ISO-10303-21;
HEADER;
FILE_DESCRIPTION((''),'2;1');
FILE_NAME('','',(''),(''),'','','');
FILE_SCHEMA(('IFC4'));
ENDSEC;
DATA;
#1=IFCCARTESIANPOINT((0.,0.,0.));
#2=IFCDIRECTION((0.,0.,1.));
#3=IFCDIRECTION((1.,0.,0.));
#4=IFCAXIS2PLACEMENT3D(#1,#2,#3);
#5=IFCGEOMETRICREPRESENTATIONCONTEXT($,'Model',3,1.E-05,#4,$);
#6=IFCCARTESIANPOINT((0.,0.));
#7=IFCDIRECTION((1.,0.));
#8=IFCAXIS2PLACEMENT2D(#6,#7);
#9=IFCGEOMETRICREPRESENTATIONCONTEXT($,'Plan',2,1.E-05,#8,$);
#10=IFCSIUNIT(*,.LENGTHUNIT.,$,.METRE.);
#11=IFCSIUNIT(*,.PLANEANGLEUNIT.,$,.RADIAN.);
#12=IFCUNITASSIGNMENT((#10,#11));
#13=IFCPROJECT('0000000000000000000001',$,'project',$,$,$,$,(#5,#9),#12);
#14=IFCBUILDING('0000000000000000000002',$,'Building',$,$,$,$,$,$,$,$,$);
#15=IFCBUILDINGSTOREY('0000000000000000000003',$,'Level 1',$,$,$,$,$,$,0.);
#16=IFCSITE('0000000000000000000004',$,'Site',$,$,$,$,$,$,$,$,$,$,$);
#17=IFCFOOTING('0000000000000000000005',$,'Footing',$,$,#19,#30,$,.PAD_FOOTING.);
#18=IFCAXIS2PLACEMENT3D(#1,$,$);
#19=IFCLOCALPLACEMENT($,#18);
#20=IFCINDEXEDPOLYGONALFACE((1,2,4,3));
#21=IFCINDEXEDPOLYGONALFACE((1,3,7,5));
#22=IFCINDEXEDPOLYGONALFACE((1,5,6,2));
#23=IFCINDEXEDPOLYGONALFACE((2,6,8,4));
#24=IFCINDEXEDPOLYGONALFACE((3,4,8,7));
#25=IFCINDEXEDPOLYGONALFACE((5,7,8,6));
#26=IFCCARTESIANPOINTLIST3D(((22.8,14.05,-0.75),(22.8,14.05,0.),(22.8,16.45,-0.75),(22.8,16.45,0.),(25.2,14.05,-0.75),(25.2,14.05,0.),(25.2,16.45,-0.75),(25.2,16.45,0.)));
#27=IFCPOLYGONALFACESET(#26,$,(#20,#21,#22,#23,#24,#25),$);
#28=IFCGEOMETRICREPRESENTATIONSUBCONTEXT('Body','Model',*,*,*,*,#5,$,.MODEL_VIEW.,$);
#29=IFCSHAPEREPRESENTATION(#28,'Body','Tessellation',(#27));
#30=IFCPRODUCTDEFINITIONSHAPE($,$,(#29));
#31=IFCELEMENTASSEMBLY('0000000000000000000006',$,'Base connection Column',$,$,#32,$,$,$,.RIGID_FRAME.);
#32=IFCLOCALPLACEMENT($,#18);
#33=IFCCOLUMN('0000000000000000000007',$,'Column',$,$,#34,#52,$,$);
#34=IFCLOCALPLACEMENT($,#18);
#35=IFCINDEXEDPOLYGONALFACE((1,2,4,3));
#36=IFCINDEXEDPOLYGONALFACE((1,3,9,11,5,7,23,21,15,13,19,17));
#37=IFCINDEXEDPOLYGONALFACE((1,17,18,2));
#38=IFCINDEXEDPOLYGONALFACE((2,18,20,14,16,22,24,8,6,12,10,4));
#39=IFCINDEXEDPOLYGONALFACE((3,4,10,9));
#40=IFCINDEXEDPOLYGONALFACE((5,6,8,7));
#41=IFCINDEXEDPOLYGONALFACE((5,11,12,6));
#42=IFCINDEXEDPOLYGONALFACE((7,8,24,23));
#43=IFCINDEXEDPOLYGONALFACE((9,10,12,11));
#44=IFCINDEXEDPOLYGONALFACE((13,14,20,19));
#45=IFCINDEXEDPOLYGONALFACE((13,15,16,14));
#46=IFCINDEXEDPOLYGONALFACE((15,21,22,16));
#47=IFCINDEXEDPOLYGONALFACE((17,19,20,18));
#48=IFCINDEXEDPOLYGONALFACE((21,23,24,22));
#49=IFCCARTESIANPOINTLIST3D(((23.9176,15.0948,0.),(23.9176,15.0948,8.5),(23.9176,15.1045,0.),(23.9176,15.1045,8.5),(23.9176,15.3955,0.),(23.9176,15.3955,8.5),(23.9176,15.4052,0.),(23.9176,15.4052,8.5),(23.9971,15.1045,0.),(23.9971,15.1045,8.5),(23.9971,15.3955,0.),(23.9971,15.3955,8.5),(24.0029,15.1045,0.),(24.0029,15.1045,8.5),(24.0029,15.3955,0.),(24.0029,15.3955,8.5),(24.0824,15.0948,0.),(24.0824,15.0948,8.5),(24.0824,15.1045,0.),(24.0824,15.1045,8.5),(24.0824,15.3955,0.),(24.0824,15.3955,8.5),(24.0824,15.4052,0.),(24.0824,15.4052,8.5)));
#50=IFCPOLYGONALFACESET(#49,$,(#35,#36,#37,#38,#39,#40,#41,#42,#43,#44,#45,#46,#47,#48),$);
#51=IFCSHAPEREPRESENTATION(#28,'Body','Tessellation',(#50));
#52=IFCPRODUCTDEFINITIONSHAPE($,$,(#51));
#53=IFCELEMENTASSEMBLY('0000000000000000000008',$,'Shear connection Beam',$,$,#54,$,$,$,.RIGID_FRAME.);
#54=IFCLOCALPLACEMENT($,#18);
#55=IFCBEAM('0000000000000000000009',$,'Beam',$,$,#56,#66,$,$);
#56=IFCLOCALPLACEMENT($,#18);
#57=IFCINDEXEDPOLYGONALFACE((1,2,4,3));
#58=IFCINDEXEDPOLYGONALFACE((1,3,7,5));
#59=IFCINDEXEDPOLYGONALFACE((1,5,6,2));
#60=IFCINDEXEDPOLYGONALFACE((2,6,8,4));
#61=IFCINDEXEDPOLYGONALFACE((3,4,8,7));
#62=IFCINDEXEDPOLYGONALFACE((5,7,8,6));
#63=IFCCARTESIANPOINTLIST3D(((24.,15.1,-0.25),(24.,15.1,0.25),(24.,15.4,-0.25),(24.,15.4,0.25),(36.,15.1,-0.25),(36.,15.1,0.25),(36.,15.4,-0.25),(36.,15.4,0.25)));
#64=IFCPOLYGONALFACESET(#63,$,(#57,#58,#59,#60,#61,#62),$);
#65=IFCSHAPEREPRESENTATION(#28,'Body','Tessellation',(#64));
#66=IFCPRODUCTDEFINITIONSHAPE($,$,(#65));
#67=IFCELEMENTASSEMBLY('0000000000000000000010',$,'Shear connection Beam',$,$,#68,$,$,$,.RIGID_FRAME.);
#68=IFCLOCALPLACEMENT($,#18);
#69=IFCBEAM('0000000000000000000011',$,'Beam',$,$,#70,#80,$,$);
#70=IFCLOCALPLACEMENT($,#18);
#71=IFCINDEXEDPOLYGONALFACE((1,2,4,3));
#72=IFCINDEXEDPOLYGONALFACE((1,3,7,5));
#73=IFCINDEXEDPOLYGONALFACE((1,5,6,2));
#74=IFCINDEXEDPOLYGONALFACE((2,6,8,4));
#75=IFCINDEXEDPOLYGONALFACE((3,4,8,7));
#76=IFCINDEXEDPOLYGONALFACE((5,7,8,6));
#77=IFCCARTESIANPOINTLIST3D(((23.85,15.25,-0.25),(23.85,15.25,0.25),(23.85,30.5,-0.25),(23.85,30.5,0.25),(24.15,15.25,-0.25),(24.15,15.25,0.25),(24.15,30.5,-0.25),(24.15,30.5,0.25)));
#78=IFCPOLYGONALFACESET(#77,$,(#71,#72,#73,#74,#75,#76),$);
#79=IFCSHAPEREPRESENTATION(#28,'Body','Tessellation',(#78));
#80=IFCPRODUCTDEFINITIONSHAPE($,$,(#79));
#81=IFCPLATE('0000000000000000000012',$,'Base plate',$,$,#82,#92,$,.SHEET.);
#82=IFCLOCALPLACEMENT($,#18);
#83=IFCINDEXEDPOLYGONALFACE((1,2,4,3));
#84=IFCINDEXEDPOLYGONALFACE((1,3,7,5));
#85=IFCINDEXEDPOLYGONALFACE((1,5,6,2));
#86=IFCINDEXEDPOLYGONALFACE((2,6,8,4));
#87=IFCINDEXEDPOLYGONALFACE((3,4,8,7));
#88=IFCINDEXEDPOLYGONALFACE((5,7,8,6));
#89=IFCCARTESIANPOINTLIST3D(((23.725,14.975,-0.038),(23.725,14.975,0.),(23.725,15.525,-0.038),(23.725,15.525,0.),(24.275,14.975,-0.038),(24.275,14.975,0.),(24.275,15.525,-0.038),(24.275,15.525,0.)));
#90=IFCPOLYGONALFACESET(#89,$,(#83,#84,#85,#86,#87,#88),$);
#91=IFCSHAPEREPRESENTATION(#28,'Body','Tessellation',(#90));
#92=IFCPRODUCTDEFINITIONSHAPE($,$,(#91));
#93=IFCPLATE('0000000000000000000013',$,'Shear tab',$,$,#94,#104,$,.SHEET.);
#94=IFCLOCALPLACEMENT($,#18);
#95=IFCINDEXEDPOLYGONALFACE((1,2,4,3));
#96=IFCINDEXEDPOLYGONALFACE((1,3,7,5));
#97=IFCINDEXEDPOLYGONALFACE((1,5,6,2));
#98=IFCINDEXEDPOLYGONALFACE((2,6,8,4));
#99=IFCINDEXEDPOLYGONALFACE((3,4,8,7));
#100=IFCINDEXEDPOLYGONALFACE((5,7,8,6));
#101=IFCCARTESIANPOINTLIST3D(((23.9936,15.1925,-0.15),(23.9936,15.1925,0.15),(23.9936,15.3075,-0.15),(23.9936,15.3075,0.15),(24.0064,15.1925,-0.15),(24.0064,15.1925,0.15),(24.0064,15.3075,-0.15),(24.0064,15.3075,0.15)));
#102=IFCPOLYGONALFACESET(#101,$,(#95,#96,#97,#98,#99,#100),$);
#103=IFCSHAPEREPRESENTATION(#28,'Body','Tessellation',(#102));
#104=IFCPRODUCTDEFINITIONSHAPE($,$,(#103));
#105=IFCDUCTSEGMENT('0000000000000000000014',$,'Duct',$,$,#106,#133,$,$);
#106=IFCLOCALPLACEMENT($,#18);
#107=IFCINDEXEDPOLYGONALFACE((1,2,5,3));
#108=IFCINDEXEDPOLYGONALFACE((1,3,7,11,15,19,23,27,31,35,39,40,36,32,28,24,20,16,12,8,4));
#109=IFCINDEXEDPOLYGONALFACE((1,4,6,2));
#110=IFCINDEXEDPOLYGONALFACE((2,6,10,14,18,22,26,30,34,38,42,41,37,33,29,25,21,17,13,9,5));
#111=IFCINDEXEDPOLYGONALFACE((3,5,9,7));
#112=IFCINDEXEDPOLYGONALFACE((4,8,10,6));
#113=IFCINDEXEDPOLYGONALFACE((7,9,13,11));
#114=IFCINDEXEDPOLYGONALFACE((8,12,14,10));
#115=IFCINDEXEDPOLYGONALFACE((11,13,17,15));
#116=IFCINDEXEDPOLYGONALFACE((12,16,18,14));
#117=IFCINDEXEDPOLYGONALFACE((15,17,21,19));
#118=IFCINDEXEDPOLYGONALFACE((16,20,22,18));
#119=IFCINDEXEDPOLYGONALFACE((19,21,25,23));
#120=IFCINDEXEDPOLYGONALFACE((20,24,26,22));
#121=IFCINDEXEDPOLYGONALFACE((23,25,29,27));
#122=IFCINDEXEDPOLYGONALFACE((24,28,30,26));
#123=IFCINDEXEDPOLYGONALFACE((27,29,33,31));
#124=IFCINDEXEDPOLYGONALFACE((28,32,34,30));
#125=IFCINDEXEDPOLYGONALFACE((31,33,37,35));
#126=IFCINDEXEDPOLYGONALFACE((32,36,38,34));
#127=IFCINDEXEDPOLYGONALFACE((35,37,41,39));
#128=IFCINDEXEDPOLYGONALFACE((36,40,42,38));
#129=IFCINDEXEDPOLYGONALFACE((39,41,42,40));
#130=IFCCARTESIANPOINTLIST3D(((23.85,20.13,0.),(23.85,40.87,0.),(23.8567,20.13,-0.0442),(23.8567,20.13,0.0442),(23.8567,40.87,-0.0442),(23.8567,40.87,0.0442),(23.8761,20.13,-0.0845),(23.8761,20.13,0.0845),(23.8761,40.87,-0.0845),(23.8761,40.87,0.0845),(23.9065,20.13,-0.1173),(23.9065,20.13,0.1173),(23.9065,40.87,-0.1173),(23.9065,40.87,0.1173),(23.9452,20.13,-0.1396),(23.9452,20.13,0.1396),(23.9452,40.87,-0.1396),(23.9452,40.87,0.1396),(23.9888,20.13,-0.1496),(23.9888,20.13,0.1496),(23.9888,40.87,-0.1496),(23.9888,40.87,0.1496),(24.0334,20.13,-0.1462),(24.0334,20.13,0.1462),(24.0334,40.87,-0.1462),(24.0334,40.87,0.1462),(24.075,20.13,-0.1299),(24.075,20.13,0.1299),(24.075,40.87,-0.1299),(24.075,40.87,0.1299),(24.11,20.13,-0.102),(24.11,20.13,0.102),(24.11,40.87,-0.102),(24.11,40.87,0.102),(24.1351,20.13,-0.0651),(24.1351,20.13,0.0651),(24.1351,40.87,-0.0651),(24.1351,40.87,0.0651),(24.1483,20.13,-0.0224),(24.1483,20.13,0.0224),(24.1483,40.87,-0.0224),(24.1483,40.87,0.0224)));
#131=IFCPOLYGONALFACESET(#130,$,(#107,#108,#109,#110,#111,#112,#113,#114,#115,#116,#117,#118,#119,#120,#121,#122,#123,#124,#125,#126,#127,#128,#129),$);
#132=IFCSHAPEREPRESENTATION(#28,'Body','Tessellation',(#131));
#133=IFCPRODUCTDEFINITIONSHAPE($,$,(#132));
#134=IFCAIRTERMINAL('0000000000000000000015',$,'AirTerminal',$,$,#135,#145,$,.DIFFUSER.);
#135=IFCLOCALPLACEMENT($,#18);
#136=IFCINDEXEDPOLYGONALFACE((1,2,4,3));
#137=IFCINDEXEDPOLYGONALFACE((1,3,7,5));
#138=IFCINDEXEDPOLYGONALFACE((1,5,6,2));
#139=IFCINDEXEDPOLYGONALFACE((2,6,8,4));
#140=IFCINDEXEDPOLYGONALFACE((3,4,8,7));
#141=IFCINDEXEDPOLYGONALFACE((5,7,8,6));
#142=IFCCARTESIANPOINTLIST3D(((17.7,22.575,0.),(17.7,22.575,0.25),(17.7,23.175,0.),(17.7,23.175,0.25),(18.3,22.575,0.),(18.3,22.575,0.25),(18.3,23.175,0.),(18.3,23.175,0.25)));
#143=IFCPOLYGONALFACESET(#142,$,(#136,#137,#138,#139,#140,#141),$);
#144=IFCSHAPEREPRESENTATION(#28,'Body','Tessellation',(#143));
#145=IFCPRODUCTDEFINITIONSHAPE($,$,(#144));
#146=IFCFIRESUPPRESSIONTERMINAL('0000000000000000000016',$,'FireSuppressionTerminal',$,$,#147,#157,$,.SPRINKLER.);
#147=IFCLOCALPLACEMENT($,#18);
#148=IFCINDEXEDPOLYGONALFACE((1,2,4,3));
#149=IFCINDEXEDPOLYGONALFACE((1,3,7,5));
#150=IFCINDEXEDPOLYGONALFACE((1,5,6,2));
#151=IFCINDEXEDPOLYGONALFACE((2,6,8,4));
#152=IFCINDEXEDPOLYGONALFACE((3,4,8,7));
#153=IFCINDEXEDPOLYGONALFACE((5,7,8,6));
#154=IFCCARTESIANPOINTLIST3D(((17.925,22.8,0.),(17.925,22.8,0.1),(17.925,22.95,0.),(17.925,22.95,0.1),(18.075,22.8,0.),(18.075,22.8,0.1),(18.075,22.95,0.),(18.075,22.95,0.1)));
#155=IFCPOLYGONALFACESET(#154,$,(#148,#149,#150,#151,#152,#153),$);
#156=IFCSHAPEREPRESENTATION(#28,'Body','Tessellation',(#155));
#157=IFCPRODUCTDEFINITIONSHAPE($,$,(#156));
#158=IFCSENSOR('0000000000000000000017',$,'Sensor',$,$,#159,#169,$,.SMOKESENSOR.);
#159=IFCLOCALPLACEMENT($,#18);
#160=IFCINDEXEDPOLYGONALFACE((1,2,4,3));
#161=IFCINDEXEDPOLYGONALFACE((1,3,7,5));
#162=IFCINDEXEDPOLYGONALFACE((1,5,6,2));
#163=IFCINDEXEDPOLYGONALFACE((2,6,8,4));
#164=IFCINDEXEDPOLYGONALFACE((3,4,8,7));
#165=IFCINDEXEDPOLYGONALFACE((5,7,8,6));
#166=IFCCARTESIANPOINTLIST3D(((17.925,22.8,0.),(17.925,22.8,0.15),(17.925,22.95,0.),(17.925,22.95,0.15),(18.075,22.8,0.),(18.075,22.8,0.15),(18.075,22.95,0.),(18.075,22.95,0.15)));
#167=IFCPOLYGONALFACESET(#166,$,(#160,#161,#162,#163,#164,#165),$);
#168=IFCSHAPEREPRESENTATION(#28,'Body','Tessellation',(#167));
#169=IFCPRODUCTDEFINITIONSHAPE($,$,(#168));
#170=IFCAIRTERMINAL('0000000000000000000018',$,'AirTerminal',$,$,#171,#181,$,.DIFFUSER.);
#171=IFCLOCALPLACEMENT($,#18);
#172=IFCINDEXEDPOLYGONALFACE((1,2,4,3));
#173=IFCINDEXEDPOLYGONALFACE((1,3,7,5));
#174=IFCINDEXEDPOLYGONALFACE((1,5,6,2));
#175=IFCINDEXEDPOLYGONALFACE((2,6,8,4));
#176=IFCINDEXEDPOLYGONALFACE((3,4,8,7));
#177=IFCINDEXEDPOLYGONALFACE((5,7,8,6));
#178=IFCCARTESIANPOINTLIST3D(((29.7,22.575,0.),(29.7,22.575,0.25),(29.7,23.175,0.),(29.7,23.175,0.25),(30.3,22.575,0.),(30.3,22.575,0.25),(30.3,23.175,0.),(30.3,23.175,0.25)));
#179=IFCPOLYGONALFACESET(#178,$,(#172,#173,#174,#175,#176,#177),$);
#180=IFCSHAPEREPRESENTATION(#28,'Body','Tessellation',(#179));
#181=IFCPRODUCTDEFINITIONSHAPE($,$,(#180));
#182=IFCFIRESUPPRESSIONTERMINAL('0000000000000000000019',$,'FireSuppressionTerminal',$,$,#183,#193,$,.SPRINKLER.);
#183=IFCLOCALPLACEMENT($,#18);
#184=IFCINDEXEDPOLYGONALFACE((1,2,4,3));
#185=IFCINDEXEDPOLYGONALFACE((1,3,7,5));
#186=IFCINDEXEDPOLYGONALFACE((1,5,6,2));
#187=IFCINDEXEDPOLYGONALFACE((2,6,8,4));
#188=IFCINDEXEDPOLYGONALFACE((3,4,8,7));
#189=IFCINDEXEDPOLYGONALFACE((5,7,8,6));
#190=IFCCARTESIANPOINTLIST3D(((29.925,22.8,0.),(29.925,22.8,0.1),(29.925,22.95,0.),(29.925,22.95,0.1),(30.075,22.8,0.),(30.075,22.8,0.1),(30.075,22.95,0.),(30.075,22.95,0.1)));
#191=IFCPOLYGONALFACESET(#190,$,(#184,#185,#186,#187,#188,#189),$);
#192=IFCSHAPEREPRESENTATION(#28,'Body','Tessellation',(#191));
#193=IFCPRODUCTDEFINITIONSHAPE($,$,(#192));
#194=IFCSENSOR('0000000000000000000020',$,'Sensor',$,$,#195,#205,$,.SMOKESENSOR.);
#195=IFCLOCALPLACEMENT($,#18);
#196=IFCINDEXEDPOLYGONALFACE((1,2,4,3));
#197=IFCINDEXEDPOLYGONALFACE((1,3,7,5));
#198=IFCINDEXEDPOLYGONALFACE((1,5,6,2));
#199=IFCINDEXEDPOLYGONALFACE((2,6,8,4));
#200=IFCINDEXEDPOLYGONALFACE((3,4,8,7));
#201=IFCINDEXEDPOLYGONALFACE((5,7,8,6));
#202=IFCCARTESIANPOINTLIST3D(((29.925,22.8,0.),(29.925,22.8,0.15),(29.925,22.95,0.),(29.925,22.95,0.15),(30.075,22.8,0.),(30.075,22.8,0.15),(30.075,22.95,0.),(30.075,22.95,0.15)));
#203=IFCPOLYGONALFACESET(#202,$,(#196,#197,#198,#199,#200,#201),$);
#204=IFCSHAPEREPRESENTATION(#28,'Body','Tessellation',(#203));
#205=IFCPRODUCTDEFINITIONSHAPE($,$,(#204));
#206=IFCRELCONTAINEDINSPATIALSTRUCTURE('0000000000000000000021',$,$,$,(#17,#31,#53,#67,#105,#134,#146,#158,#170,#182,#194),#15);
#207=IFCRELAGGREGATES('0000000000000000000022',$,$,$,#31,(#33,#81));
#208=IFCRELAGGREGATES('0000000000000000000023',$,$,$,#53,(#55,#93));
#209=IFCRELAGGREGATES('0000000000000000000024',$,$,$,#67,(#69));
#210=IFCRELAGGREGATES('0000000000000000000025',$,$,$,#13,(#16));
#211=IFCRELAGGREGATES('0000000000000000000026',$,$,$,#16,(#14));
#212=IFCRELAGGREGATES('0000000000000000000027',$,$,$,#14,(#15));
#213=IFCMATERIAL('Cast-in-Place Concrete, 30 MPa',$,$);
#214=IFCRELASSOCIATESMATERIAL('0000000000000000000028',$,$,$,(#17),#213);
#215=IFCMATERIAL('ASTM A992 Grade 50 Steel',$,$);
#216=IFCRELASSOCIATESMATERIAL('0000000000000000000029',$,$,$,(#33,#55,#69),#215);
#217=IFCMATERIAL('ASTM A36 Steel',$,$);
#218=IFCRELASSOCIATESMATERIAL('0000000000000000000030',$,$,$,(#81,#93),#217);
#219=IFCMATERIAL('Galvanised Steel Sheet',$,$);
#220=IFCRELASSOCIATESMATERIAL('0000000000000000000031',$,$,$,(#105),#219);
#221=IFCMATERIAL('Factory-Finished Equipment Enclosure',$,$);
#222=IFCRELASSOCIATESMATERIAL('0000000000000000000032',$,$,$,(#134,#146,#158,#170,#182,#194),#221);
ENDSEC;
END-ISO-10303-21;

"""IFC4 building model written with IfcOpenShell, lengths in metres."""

from ifc_helpers import new_model, si_unit, frame, origin_with_axes, origin_2d_with_axis, place, context, subcontext, project, spatial, rectangle, circle, i_section, extrude, material, element, aggregate, save


model = new_model("IFC4")

# Units and contexts
model_context = context("Model", 3, precision=1e-05, world=origin_with_axes())
plan_context = context("Plan", 2, precision=1e-05, world=origin_2d_with_axis())
body_context = subcontext(model_context, "Body", "Model", "MODEL_VIEW")
ifc_project = project(units=[si_unit("LENGTHUNIT", "METRE"), si_unit("PLANEANGLEUNIT", "RADIAN")], contexts=[model_context, plan_context])

# Site, building, storey
site = spatial("IfcSite", under=ifc_project, Name="Site")
building = spatial("IfcBuilding", under=site, Name="Building")
storey = spatial("IfcBuildingStorey", under=building, Name="Level 1", Elevation=0.0)

# Footing
ifc_material_1 = material(Name="Cast-in-Place Concrete, 30 MPa")
footing_placement = place(None, frame((24.0, 15.25, -0.75), z_axis=(0.0, 0.0, 1.0), x_axis=(1.0, 0.0, 0.0)))
element("IfcFooting", 1, at=footing_placement, inside=storey, material=ifc_material_1, Name="Footing", PredefinedType="PAD_FOOTING", context=body_context, shape_type="SweptSolid", body=[
    extrude(rectangle(XDim=2.4, YDim=2.4, at=origin_2d_with_axis()), origin_with_axes(), (0.0, 0.0, 1.0), 0.75),
])

# Element assembly, column
assembly_1 = element("IfcElementAssembly", 2, inside=storey, Name="Base connection Column", PredefinedType="RIGID_FRAME")
ifc_material_2 = material(Name="ASTM A992 Grade 50 Steel")
column_placement = place(None, frame((24.0, 15.25, 0.0), z_axis=(0.0, 0.0, 1.0), x_axis=(1.0, 0.0, 0.0)))
column = element("IfcColumn", 3, at=column_placement, material=ifc_material_2, Name="Column", context=body_context, shape_type="SweptSolid", body=[
    extrude(i_section(OverallWidth=0.1648, OverallDepth=0.3104, WebThickness=0.0058, FlangeThickness=0.0097, at=origin_2d_with_axis()), origin_with_axes(), (0.0, 0.0, 1.0), 8.5),
])

# Element assemblies, beams
assembly_2 = element("IfcElementAssembly", 4, inside=storey, Name="Shear connection Beam", PredefinedType="RIGID_FRAME")
beam_1_placement = place(None, frame((24.0, 15.25, 0.0), z_axis=(1.0, 0.0, 0.0), x_axis=(0.0, 1.0, 0.0)))
beam_1 = element("IfcBeam", 5, at=beam_1_placement, material=ifc_material_2, Name="Beam", context=body_context, shape_type="SweptSolid", body=[
    extrude(rectangle(XDim=0.3, YDim=0.5, at=origin_2d_with_axis()), origin_with_axes(), (0.0, 0.0, 1.0), 12.0),
])
assembly_3 = element("IfcElementAssembly", 6, inside=storey, Name="Shear connection Beam", PredefinedType="RIGID_FRAME")
beam_2_placement = place(None, frame((24.0, 15.25, 0.0), z_axis=(0.0, 1.0, 0.0), x_axis=(-1.0, 0.0, 0.0)))
beam_2 = element("IfcBeam", 7, at=beam_2_placement, material=ifc_material_2, Name="Beam", context=body_context, shape_type="SweptSolid", body=[
    extrude(rectangle(XDim=0.3, YDim=0.5, at=origin_2d_with_axis()), origin_with_axes(), (0.0, 0.0, 1.0), 15.25),
])

# Plates
ifc_material_3 = material(Name="ASTM A36 Steel")
plate_1_placement = place(None, frame((24.0, 15.25, -0.038), z_axis=(0.0, 0.0, 1.0), x_axis=(1.0, 0.0, 0.0)))
plate_1 = element("IfcPlate", 8, at=plate_1_placement, material=ifc_material_3, Name="Base plate", PredefinedType="SHEET", context=body_context, shape_type="SweptSolid", body=[
    extrude(rectangle(XDim=0.55, YDim=0.55, at=origin_2d_with_axis()), origin_with_axes(), (0.0, 0.0, 1.0), 0.038),
])
plate_2_placement = place(None, frame((24.0, 15.25, -0.15), z_axis=(0.0, 0.0, 1.0), x_axis=(1.0, 0.0, 0.0)))
plate_2 = element("IfcPlate", 9, at=plate_2_placement, material=ifc_material_3, Name="Shear tab", PredefinedType="SHEET", context=body_context, shape_type="SweptSolid", body=[
    extrude(rectangle(XDim=0.0127, YDim=0.115, at=origin_2d_with_axis()), origin_with_axes(), (0.0, 0.0, 1.0), 0.3),
])

# Duct segment
ifc_material_4 = material(Name="Galvanised Steel Sheet")
duct_segment_placement = place(None, frame((24.0, 20.13, 0.0), z_axis=(0.0, 1.0, 0.0), x_axis=(-1.0, 0.0, 0.0)))
element("IfcDuctSegment", 10, at=duct_segment_placement, inside=storey, material=ifc_material_4, Name="Duct", context=body_context, shape_type="SweptSolid", body=[
    extrude(circle(Radius=0.15, at=origin_2d_with_axis()), origin_with_axes(), (0.0, 0.0, 1.0), 20.74),
])

# Air terminal
ifc_material_5 = material(Name="Factory-Finished Equipment Enclosure")
air_terminal_1_placement = place(None, frame((18.0, 22.875, 0.0), z_axis=(0.0, 0.0, 1.0), x_axis=(1.0, 0.0, 0.0)))
element("IfcAirTerminal", 11, at=air_terminal_1_placement, inside=storey, material=ifc_material_5, Name="AirTerminal", PredefinedType="DIFFUSER", context=body_context, shape_type="SweptSolid", body=[
    extrude(rectangle(XDim=0.6, YDim=0.6, at=origin_2d_with_axis()), origin_with_axes(), (0.0, 0.0, 1.0), 0.25),
])

# Fire suppression terminal
fire_suppression_terminal_1_placement = place(None, frame((18.0, 22.875, 0.0), z_axis=(0.0, 0.0, 1.0), x_axis=(1.0, 0.0, 0.0)))
element("IfcFireSuppressionTerminal", 12, at=fire_suppression_terminal_1_placement, inside=storey, material=ifc_material_5, Name="FireSuppressionTerminal", PredefinedType="SPRINKLER", context=body_context, shape_type="SweptSolid", body=[
    extrude(rectangle(XDim=0.15, YDim=0.15, at=origin_2d_with_axis()), origin_with_axes(), (0.0, 0.0, 1.0), 0.1),
])

# Sensor
sensor_1_placement = place(None, frame((18.0, 22.875, 0.0), z_axis=(0.0, 0.0, 1.0), x_axis=(1.0, 0.0, 0.0)))
element("IfcSensor", 13, at=sensor_1_placement, inside=storey, material=ifc_material_5, Name="Sensor", PredefinedType="SMOKESENSOR", context=body_context, shape_type="SweptSolid", body=[
    extrude(rectangle(XDim=0.15, YDim=0.15, at=origin_2d_with_axis()), origin_with_axes(), (0.0, 0.0, 1.0), 0.15),
])

# Air terminal
air_terminal_2_placement = place(None, frame((30.0, 22.875, 0.0), z_axis=(0.0, 0.0, 1.0), x_axis=(1.0, 0.0, 0.0)))
element("IfcAirTerminal", 14, at=air_terminal_2_placement, inside=storey, material=ifc_material_5, Name="AirTerminal", PredefinedType="DIFFUSER", context=body_context, shape_type="SweptSolid", body=[
    extrude(rectangle(XDim=0.6, YDim=0.6, at=origin_2d_with_axis()), origin_with_axes(), (0.0, 0.0, 1.0), 0.25),
])

# Fire suppression terminal
fire_suppression_terminal_2_placement = place(None, frame((30.0, 22.875, 0.0), z_axis=(0.0, 0.0, 1.0), x_axis=(1.0, 0.0, 0.0)))
element("IfcFireSuppressionTerminal", 15, at=fire_suppression_terminal_2_placement, inside=storey, material=ifc_material_5, Name="FireSuppressionTerminal", PredefinedType="SPRINKLER", context=body_context, shape_type="SweptSolid", body=[
    extrude(rectangle(XDim=0.15, YDim=0.15, at=origin_2d_with_axis()), origin_with_axes(), (0.0, 0.0, 1.0), 0.1),
])

# Sensor
sensor_2_placement = place(None, frame((30.0, 22.875, 0.0), z_axis=(0.0, 0.0, 1.0), x_axis=(1.0, 0.0, 0.0)))
element("IfcSensor", 16, at=sensor_2_placement, inside=storey, material=ifc_material_5, Name="Sensor", PredefinedType="SMOKESENSOR", context=body_context, shape_type="SweptSolid", body=[
    extrude(rectangle(XDim=0.15, YDim=0.15, at=origin_2d_with_axis()), origin_with_axes(), (0.0, 0.0, 1.0), 0.15),
])

aggregate(assembly_1, [column, plate_1])

aggregate(assembly_2, [beam_1, plate_2])
aggregate(assembly_3, [beam_2])

save(model, "model.ifc")
